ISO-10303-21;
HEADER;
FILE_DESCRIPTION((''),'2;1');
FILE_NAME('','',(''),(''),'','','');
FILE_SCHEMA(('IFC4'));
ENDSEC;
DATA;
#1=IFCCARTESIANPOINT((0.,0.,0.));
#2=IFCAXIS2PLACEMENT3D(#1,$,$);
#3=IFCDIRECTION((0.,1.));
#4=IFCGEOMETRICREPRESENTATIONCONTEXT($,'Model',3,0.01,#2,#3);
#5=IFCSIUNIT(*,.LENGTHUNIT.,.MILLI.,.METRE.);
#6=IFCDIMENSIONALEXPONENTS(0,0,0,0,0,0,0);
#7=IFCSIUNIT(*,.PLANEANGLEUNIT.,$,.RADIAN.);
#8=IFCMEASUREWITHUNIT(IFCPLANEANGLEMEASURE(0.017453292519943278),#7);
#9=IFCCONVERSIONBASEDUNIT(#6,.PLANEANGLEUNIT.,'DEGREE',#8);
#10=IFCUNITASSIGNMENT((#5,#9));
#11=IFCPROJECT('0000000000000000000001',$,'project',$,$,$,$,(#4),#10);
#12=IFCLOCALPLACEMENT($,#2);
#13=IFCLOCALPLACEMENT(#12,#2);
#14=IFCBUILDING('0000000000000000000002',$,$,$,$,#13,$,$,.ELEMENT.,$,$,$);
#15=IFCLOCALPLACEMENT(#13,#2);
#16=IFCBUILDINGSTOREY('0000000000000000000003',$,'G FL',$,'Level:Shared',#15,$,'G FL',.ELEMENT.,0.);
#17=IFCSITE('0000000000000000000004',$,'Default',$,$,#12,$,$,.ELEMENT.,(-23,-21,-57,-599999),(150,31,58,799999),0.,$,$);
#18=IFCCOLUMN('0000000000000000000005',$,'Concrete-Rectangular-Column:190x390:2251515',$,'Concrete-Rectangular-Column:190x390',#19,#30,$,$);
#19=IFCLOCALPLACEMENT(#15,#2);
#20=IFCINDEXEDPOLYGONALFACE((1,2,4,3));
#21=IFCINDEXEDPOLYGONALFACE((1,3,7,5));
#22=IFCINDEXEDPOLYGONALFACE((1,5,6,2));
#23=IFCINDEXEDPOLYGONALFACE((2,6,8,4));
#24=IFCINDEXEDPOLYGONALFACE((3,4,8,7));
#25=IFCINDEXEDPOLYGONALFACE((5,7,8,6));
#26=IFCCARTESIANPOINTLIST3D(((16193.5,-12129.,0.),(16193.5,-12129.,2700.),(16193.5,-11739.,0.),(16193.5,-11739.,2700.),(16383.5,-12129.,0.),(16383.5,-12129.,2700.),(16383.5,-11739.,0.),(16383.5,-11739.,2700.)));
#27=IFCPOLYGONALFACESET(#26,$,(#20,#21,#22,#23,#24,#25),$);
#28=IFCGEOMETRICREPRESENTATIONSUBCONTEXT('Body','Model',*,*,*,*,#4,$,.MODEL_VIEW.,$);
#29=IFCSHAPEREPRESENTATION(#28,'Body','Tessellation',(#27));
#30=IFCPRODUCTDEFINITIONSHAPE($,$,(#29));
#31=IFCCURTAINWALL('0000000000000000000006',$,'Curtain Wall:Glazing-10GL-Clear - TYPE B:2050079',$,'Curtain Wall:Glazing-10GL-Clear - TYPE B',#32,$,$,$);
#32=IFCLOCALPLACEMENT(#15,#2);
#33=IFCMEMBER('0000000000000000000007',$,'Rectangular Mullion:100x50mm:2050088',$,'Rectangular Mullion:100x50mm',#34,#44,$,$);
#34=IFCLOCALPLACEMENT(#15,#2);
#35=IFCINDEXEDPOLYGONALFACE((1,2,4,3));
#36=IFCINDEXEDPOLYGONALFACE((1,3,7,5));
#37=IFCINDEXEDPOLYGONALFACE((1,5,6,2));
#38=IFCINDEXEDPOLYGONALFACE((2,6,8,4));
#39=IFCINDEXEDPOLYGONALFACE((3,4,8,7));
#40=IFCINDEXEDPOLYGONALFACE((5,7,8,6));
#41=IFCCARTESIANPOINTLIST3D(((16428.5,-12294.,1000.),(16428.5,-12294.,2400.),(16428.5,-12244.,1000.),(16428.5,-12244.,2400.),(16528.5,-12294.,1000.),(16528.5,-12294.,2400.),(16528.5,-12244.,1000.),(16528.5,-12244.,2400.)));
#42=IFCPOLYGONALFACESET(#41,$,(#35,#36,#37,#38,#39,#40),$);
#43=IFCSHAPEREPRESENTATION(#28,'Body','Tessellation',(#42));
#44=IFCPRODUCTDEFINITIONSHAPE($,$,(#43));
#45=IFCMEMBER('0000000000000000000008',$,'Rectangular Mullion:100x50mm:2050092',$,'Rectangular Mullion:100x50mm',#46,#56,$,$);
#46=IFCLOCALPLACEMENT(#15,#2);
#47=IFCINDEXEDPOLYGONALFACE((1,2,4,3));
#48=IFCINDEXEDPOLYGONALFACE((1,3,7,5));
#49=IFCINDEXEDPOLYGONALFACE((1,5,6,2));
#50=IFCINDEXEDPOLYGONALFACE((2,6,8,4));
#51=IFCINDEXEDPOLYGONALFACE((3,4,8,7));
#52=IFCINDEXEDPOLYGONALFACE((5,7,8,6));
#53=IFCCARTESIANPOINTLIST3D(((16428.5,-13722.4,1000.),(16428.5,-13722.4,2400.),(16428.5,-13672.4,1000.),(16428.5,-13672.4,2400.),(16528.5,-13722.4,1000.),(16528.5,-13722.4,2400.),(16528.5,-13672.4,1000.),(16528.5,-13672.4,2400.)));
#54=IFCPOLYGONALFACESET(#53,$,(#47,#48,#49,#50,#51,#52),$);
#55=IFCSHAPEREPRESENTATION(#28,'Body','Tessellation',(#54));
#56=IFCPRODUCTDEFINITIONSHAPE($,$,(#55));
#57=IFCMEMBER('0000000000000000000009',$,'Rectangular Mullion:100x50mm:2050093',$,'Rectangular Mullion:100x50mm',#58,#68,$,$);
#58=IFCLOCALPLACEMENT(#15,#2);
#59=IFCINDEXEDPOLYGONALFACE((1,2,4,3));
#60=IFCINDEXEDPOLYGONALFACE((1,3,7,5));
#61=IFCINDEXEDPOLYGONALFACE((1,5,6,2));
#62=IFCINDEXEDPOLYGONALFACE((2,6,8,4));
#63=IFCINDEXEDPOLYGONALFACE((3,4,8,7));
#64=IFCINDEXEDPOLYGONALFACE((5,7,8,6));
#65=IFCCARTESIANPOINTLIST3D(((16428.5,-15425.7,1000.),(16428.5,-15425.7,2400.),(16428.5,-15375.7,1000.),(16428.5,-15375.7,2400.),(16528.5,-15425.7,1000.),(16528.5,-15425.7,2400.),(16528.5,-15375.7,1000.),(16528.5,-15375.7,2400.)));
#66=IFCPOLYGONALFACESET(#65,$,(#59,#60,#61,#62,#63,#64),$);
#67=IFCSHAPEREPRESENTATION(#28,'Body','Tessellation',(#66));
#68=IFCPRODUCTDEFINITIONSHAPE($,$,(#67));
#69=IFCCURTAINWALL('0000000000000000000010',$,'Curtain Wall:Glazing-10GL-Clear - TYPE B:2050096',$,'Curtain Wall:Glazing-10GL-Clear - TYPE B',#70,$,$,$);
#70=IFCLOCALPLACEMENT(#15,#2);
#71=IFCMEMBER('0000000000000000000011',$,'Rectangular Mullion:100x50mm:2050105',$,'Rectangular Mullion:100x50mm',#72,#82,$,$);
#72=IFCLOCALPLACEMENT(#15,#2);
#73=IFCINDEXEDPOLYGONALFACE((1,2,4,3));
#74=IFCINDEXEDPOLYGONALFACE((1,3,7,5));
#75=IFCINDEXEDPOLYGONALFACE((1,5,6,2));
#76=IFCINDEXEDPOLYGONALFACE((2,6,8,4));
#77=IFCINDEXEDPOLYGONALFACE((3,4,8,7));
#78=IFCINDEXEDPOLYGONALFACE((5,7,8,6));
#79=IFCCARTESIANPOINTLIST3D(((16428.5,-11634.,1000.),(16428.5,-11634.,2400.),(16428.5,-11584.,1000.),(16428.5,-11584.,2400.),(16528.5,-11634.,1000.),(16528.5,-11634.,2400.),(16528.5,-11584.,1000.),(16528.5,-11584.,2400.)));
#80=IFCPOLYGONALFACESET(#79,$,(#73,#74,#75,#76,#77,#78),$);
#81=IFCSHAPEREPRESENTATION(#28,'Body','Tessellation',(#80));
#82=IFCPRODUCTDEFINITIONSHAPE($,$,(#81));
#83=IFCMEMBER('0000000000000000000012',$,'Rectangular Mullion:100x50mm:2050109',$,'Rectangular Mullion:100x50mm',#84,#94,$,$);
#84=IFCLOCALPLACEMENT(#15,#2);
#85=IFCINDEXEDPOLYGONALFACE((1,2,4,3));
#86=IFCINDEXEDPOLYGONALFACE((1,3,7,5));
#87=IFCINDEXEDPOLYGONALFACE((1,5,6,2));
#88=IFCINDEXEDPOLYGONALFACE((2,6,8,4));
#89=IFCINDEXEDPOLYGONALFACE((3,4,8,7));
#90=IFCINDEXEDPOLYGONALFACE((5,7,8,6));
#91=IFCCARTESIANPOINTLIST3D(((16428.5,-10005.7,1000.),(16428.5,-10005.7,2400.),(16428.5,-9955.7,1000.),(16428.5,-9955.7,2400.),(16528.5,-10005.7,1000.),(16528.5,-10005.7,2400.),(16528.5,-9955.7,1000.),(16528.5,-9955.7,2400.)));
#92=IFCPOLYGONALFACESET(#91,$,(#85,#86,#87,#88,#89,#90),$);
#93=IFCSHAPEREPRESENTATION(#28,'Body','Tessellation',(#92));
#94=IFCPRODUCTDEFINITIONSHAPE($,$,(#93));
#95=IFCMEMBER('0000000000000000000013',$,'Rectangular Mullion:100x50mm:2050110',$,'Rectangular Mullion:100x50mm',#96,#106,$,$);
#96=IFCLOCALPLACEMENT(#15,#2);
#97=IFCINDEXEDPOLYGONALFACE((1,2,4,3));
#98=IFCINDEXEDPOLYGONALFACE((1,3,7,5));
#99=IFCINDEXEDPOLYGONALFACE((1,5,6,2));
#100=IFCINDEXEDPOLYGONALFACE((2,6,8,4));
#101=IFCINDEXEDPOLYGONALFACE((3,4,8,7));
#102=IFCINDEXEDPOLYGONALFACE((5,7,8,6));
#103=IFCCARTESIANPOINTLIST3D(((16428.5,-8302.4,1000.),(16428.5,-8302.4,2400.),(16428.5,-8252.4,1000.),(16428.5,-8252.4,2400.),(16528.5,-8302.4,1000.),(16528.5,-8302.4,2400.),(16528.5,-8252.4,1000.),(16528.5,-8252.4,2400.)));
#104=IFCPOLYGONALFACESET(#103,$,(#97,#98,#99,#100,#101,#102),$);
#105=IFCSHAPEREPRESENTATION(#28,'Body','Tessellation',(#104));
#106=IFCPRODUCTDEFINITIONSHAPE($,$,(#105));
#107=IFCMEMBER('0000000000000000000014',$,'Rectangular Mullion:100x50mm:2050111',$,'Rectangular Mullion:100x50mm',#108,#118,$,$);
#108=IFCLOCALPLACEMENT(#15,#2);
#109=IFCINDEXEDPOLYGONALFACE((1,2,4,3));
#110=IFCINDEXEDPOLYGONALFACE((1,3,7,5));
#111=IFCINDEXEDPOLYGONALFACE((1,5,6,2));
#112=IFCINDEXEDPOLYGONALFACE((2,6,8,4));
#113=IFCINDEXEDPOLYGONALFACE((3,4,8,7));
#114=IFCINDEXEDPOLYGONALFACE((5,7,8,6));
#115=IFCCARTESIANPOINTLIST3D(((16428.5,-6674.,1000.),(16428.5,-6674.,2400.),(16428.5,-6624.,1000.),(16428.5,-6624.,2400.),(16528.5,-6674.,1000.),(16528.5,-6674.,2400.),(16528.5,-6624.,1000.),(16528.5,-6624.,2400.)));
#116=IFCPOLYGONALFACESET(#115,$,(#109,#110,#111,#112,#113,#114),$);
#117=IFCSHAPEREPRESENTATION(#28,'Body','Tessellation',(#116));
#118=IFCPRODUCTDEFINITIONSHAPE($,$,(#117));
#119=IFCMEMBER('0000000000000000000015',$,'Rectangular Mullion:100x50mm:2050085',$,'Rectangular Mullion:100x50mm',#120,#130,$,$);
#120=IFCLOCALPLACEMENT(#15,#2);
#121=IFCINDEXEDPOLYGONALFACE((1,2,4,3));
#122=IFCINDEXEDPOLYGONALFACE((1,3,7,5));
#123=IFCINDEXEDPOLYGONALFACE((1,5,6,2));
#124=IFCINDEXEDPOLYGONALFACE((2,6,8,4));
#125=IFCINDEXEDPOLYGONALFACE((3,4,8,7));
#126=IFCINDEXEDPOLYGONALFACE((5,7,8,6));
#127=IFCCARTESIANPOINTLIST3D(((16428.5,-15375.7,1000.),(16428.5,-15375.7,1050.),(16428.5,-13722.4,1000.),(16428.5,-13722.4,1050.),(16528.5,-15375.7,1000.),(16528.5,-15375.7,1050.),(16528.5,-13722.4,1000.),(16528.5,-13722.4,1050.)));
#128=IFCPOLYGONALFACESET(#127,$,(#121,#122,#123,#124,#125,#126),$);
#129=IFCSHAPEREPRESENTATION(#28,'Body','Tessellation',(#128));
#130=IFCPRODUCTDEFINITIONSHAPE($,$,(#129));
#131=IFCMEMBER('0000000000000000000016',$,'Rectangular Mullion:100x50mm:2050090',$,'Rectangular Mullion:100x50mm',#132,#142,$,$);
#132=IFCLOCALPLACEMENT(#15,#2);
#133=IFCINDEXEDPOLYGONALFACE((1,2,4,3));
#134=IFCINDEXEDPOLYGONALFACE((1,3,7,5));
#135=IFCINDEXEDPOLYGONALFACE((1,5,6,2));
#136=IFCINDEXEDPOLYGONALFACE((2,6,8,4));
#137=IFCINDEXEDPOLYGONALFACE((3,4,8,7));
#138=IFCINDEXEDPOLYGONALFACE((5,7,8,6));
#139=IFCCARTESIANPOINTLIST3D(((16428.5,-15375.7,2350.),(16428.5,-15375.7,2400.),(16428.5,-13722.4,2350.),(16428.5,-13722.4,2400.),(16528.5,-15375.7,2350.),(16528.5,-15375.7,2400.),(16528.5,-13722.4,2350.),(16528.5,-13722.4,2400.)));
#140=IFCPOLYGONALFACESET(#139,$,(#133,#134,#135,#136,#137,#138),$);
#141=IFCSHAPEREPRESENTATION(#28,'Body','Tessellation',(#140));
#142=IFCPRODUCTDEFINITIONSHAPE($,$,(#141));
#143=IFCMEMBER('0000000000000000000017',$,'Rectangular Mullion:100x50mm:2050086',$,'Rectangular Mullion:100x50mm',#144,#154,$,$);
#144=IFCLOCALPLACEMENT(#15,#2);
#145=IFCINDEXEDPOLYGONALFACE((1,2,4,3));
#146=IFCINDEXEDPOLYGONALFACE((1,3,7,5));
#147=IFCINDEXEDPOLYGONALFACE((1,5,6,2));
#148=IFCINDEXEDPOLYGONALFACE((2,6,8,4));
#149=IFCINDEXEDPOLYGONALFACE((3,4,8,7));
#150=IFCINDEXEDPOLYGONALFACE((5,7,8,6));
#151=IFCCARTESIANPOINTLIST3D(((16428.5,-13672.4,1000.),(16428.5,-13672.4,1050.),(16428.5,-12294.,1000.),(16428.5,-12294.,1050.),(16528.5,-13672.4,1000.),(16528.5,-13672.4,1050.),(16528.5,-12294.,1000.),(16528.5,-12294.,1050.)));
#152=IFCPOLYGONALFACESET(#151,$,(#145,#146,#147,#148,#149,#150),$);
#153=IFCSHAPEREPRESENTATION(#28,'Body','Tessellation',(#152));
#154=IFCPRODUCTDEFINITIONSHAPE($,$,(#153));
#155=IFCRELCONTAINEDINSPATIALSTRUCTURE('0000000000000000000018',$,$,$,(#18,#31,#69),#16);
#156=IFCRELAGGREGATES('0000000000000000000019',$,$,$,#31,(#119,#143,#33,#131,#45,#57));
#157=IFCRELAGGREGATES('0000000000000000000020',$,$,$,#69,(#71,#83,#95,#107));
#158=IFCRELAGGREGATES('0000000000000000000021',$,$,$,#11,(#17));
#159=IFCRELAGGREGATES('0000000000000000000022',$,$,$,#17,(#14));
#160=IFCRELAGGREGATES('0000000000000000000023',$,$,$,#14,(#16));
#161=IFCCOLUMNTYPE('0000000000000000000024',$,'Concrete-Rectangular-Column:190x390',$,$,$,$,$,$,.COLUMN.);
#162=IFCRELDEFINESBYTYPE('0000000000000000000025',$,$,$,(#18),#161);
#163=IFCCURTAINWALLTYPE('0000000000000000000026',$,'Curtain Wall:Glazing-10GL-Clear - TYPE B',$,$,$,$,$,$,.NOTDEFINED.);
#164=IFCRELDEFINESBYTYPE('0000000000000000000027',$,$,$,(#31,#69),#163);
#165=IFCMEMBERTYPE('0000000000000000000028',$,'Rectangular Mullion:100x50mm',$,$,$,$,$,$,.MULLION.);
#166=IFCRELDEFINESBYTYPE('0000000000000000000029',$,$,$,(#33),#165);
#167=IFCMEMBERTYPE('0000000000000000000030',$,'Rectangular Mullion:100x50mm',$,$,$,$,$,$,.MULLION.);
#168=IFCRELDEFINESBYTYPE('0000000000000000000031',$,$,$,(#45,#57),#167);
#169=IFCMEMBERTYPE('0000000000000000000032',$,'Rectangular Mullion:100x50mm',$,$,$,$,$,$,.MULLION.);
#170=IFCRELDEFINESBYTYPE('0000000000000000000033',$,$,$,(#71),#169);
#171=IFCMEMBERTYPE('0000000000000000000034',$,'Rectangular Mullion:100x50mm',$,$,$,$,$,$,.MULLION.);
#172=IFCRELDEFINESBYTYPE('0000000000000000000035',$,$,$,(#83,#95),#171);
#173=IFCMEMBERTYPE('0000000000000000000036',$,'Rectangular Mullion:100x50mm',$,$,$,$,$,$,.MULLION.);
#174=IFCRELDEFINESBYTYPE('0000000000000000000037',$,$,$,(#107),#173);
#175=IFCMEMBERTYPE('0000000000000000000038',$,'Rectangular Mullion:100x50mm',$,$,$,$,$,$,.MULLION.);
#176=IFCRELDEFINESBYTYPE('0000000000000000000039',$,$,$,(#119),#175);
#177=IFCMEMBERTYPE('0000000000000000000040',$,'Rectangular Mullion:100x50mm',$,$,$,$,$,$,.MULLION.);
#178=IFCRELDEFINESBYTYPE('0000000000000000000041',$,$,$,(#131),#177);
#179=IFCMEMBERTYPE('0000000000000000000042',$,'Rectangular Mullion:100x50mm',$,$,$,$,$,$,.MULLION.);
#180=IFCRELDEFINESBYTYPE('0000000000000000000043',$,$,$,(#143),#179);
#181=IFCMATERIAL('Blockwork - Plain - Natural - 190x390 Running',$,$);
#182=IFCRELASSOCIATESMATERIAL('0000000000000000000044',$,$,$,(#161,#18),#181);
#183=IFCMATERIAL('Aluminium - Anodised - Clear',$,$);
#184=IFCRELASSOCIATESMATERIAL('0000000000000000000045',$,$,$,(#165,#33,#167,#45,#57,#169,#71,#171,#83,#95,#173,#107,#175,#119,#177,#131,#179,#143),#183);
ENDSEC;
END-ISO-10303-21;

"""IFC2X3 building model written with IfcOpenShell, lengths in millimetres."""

from ifc_helpers import new_model, entity, si_unit, converted_unit, direction, frame, frame_2d, origin, origin_2d_with_axis, place, context, subcontext, project, spatial, rectangle, extrude, source, transform, mapped, material, type_object, type_shapes, element, aggregate, save


model = new_model("IFC2X3")

# Units and contexts
model_context = context("Model", 3, precision=0.01, world=origin(), true_north=direction((0.0, 1.0)))
body_context = subcontext(model_context, "Body", "Model", "MODEL_VIEW")
ifc_project = project(units=[si_unit("LENGTHUNIT", "METRE", prefix="MILLI"), converted_unit("PLANEANGLEUNIT", "DEGREE", entity("IfcPlaneAngleMeasure", 0.017453292519943278), si_unit("PLANEANGLEUNIT", "RADIAN"), dimensions=[0, 0, 0, 0, 0, 0, 0])], contexts=[model_context])

# Site, building, storey
site_placement = place(None, origin())
site = spatial("IfcSite", under=ifc_project, at=site_placement, Name="Default", CompositionType="ELEMENT", RefLatitude=(-23, -21, -57, -599999), RefLongitude=(150, 31, 58, 799999), RefElevation=0.0)
building_placement = place(site_placement, origin())
building = spatial("IfcBuilding", under=site, at=building_placement, CompositionType="ELEMENT")
storey_placement = place(building_placement, origin())
storey = spatial("IfcBuildingStorey", under=building, at=storey_placement, Name="G FL", ObjectType="Level:Shared", LongName="G FL", CompositionType="ELEMENT", Elevation=0.0)

# Column
ifc_material_1 = material(Name="Blockwork - Plain - Natural - 190x390 Running")
column_type = type_object("IfcColumnType", Name="Concrete-Rectangular-Column:190x390", PredefinedType="COLUMN", material=ifc_material_1)
shared_shape_1 = source(origin(), body_context, "Body", "SweptSolid", [
    extrude(rectangle(XDim=190.0, YDim=390.0, at=origin_2d_with_axis()), frame((0.0, 0.0, 0.0), z_axis=(0.0, 0.0, 1.0), x_axis=(-1.0, 0.0, 0.0)), (0.0, 0.0, 1.0), 2700.0),
])
type_shapes(column_type, [shared_shape_1])
column_placement = place(storey_placement, frame((16288.5, -11934.0, 0.0)))
element("IfcColumn", 1, at=column_placement, inside=storey, type_object=column_type, material=ifc_material_1, Name="Concrete-Rectangular-Column:190x390:2251515", ObjectType="Concrete-Rectangular-Column:190x390", context=body_context, shape_type="MappedRepresentation", body=[
    mapped(shared_shape_1, transform((0.0, 0.0, 0.0), scale=1.0)),
])

# Curtain walls, members
curtain_wall_type = type_object("IfcCurtainWallType", Name="Curtain Wall:Glazing-10GL-Clear - TYPE B", PredefinedType="NOTDEFINED")
curtain_wall_1_placement = place(storey_placement, origin())
curtain_wall_1 = element("IfcCurtainWall", 2, at=curtain_wall_1_placement, inside=storey, type_object=curtain_wall_type, Name="Curtain Wall:Glazing-10GL-Clear - TYPE B:2050079", ObjectType="Curtain Wall:Glazing-10GL-Clear - TYPE B")
ifc_material_2 = material(Name="Aluminium - Anodised - Clear")
member_type_1 = type_object("IfcMemberType", Name="Rectangular Mullion:100x50mm", PredefinedType="MULLION", material=ifc_material_2)
shared_shape_2 = source(origin(), body_context, "Body", "SweptSolid", [
    extrude(rectangle(XDim=50.0, YDim=100.0, at=origin_2d_with_axis()), frame((-25.0, 0.0, -1400.0), z_axis=(0.0, 0.0, 1.0), x_axis=(-1.0, 0.0, 0.0)), (0.0, 0.0, 1.0), 1400.0),
])
type_shapes(member_type_1, [shared_shape_2])
member_1_placement = place(curtain_wall_1_placement, frame((16478.5, -12244.0, 1000.0), z_axis=(0.0, 0.0, -1.0), x_axis=(0.0, 1.0, 0.0)))
member_1 = element("IfcMember", 3, at=member_1_placement, type_object=member_type_1, material=ifc_material_2, Name="Rectangular Mullion:100x50mm:2050088", ObjectType="Rectangular Mullion:100x50mm", context=body_context, shape_type="MappedRepresentation", body=[
    mapped(shared_shape_2, transform((0.0, 0.0, 0.0), scale=1.0)),
])
member_type_2 = type_object("IfcMemberType", Name="Rectangular Mullion:100x50mm", PredefinedType="MULLION", material=ifc_material_2)
shared_shape_3 = source(origin(), body_context, "Body", "SweptSolid", [
    extrude(rectangle(XDim=50.0, YDim=100.0, at=frame_2d((0.0, 0.0), x_axis=(1.0, 0.0))), frame((0.0, 0.0, -1400.0), z_axis=(0.0, 0.0, 1.0), x_axis=(-1.0, 0.0, 0.0)), (0.0, 0.0, 1.0), 1400.0),
])
type_shapes(member_type_2, [shared_shape_3])
member_2_placement = place(curtain_wall_1_placement, frame((16478.5, -13697.4, 1000.0), z_axis=(0.0, 0.0, -1.0), x_axis=(0.0, 1.0, 0.0)))
member_2 = element("IfcMember", 4, at=member_2_placement, type_object=member_type_2, material=ifc_material_2, Name="Rectangular Mullion:100x50mm:2050092", ObjectType="Rectangular Mullion:100x50mm", context=body_context, shape_type="MappedRepresentation", body=[
    mapped(shared_shape_3, transform((0.0, 0.0, 0.0), scale=1.0)),
])
member_3_placement = place(curtain_wall_1_placement, frame((16478.5, -15400.7, 1000.0), z_axis=(0.0, 0.0, -1.0), x_axis=(0.0, 1.0, 0.0)))
member_3 = element("IfcMember", 5, at=member_3_placement, type_object=member_type_2, material=ifc_material_2, Name="Rectangular Mullion:100x50mm:2050093", ObjectType="Rectangular Mullion:100x50mm", context=body_context, shape_type="MappedRepresentation", body=[
    mapped(shared_shape_3, transform((0.0, 0.0, 0.0), scale=1.0)),
])
curtain_wall_2_placement = place(storey_placement, origin())
curtain_wall_2 = element("IfcCurtainWall", 6, at=curtain_wall_2_placement, inside=storey, type_object=curtain_wall_type, Name="Curtain Wall:Glazing-10GL-Clear - TYPE B:2050096", ObjectType="Curtain Wall:Glazing-10GL-Clear - TYPE B")
member_type_3 = type_object("IfcMemberType", Name="Rectangular Mullion:100x50mm", PredefinedType="MULLION", material=ifc_material_2)
shared_shape_4 = source(origin(), body_context, "Body", "SweptSolid", [
    extrude(rectangle(XDim=50.0, YDim=100.0, at=frame_2d((0.0, 0.0), x_axis=(1.0, 0.0))), frame((-25.0, 0.0, -1400.0), z_axis=(0.0, 0.0, 1.0), x_axis=(-1.0, 0.0, 0.0)), (0.0, 0.0, 1.0), 1400.0),
])
type_shapes(member_type_3, [shared_shape_4])
member_4_placement = place(curtain_wall_2_placement, frame((16478.5, -11634.0, 1000.0), z_axis=(0.0, 0.0, -1.0), x_axis=(0.0, -1.0, 0.0)))
member_4 = element("IfcMember", 7, at=member_4_placement, type_object=member_type_3, material=ifc_material_2, Name="Rectangular Mullion:100x50mm:2050105", ObjectType="Rectangular Mullion:100x50mm", context=body_context, shape_type="MappedRepresentation", body=[
    mapped(shared_shape_4, transform((0.0, 0.0, 0.0), scale=1.0)),
])
member_type_4 = type_object("IfcMemberType", Name="Rectangular Mullion:100x50mm", PredefinedType="MULLION", material=ifc_material_2)
shared_shape_5 = source(origin(), body_context, "Body", "SweptSolid", [
    extrude(rectangle(XDim=50.0, YDim=100.0, at=frame_2d((0.0, 0.0), x_axis=(1.0, 0.0))), frame((0.0, 0.0, -1400.0), z_axis=(0.0, 0.0, 1.0), x_axis=(-1.0, 0.0, 0.0)), (0.0, 0.0, 1.0), 1400.0),
])
type_shapes(member_type_4, [shared_shape_5])
member_5_placement = place(curtain_wall_2_placement, frame((16478.5, -9980.7, 1000.0), z_axis=(0.0, 0.0, -1.0), x_axis=(0.0, -1.0, 0.0)))
member_5 = element("IfcMember", 8, at=member_5_placement, type_object=member_type_4, material=ifc_material_2, Name="Rectangular Mullion:100x50mm:2050109", ObjectType="Rectangular Mullion:100x50mm", context=body_context, shape_type="MappedRepresentation", body=[
    mapped(shared_shape_5, transform((0.0, 0.0, 0.0), scale=1.0)),
])
member_6_placement = place(curtain_wall_2_placement, frame((16478.5, -8277.4, 1000.0), z_axis=(0.0, 0.0, -1.0), x_axis=(0.0, -1.0, 0.0)))
member_6 = element("IfcMember", 9, at=member_6_placement, type_object=member_type_4, material=ifc_material_2, Name="Rectangular Mullion:100x50mm:2050110", ObjectType="Rectangular Mullion:100x50mm", context=body_context, shape_type="MappedRepresentation", body=[
    mapped(shared_shape_5, transform((0.0, 0.0, 0.0), scale=1.0)),
])
member_type_5 = type_object("IfcMemberType", Name="Rectangular Mullion:100x50mm", PredefinedType="MULLION", material=ifc_material_2)
shared_shape_6 = source(origin(), body_context, "Body", "SweptSolid", [
    extrude(rectangle(XDim=50.0, YDim=100.0, at=origin_2d_with_axis()), frame((-25.0, 0.0, -1400.0), z_axis=(0.0, 0.0, 1.0), x_axis=(-1.0, 0.0, 0.0)), (0.0, 0.0, 1.0), 1400.0),
])
type_shapes(member_type_5, [shared_shape_6])
member_7_placement = place(curtain_wall_2_placement, frame((16478.5, -6624.0, 2400.0), z_axis=(0.0, 0.0, 1.0), x_axis=(0.0, 1.0, 0.0)))
member_7 = element("IfcMember", 10, at=member_7_placement, type_object=member_type_5, material=ifc_material_2, Name="Rectangular Mullion:100x50mm:2050111", ObjectType="Rectangular Mullion:100x50mm", context=body_context, shape_type="MappedRepresentation", body=[
    mapped(shared_shape_6, transform((0.0, 0.0, 0.0), scale=1.0)),
])

# Members
member_type_6 = type_object("IfcMemberType", Name="Rectangular Mullion:100x50mm", PredefinedType="MULLION", material=ifc_material_2)
shared_shape_7 = source(origin(), body_context, "Body", "SweptSolid", [
    extrude(rectangle(XDim=50.0, YDim=100.0, at=frame_2d((0.0, 0.0), x_axis=(1.0, 0.0))), frame((-25.0, 0.0, -1653.3), z_axis=(0.0, 0.0, 1.0), x_axis=(-1.0, 0.0, 0.0)), (0.0, 0.0, 1.0), 1653.3),
])
type_shapes(member_type_6, [shared_shape_7])
member_8_placement = place(curtain_wall_1_placement, frame((16478.5, -15375.7, 1000.0), z_axis=(0.0, -1.0, 0.0), x_axis=(0.0, 0.0, -1.0)))
member_8 = element("IfcMember", 11, at=member_8_placement, type_object=member_type_6, material=ifc_material_2, Name="Rectangular Mullion:100x50mm:2050085", ObjectType="Rectangular Mullion:100x50mm", context=body_context, shape_type="MappedRepresentation", body=[
    mapped(shared_shape_7, transform((0.0, 0.0, 0.0), scale=1.0)),
])
member_type_7 = type_object("IfcMemberType", Name="Rectangular Mullion:100x50mm", PredefinedType="MULLION", material=ifc_material_2)
shared_shape_8 = source(origin(), body_context, "Body", "SweptSolid", [
    extrude(rectangle(XDim=50.0, YDim=100.0, at=frame_2d((0.0, 0.0), x_axis=(1.0, 0.0))), frame((-25.0, 0.0, -1653.3), z_axis=(0.0, 0.0, 1.0), x_axis=(-1.0, 0.0, 0.0)), (0.0, 0.0, 1.0), 1653.3),
])
type_shapes(member_type_7, [shared_shape_8])
member_9_placement = place(curtain_wall_1_placement, frame((16478.5, -13722.4, 2400.0), z_axis=(0.0, 1.0, 0.0), x_axis=(0.0, 0.0, 1.0)))
member_9 = element("IfcMember", 12, at=member_9_placement, type_object=member_type_7, material=ifc_material_2, Name="Rectangular Mullion:100x50mm:2050090", ObjectType="Rectangular Mullion:100x50mm", context=body_context, shape_type="MappedRepresentation", body=[
    mapped(shared_shape_8, transform((0.0, 0.0, 0.0), scale=1.0)),
])
member_type_8 = type_object("IfcMemberType", Name="Rectangular Mullion:100x50mm", PredefinedType="MULLION", material=ifc_material_2)
shared_shape_9 = source(origin(), body_context, "Body", "SweptSolid", [
    extrude(rectangle(XDim=50.0, YDim=100.0, at=frame_2d((0.0, 0.0), x_axis=(1.0, 0.0))), frame((-25.0, 0.0, -1378.3), z_axis=(0.0, 0.0, 1.0), x_axis=(-1.0, 0.0, 0.0)), (0.0, 0.0, 1.0), 1378.3),
])
type_shapes(member_type_8, [shared_shape_9])
member_10_placement = place(curtain_wall_1_placement, frame((16478.5, -13672.4, 1000.0), z_axis=(0.0, -1.0, 0.0), x_axis=(0.0, 0.0, -1.0)))
member_10 = element("IfcMember", 13, at=member_10_placement, type_object=member_type_8, material=ifc_material_2, Name="Rectangular Mullion:100x50mm:2050086", ObjectType="Rectangular Mullion:100x50mm", context=body_context, shape_type="MappedRepresentation", body=[
    mapped(shared_shape_9, transform((0.0, 0.0, 0.0), scale=1.0)),
])

aggregate(curtain_wall_1, [member_8, member_10, member_1, member_9, member_2, member_3])
aggregate(curtain_wall_2, [member_4, member_5, member_6, member_7])

save(model, "model.ifc")
